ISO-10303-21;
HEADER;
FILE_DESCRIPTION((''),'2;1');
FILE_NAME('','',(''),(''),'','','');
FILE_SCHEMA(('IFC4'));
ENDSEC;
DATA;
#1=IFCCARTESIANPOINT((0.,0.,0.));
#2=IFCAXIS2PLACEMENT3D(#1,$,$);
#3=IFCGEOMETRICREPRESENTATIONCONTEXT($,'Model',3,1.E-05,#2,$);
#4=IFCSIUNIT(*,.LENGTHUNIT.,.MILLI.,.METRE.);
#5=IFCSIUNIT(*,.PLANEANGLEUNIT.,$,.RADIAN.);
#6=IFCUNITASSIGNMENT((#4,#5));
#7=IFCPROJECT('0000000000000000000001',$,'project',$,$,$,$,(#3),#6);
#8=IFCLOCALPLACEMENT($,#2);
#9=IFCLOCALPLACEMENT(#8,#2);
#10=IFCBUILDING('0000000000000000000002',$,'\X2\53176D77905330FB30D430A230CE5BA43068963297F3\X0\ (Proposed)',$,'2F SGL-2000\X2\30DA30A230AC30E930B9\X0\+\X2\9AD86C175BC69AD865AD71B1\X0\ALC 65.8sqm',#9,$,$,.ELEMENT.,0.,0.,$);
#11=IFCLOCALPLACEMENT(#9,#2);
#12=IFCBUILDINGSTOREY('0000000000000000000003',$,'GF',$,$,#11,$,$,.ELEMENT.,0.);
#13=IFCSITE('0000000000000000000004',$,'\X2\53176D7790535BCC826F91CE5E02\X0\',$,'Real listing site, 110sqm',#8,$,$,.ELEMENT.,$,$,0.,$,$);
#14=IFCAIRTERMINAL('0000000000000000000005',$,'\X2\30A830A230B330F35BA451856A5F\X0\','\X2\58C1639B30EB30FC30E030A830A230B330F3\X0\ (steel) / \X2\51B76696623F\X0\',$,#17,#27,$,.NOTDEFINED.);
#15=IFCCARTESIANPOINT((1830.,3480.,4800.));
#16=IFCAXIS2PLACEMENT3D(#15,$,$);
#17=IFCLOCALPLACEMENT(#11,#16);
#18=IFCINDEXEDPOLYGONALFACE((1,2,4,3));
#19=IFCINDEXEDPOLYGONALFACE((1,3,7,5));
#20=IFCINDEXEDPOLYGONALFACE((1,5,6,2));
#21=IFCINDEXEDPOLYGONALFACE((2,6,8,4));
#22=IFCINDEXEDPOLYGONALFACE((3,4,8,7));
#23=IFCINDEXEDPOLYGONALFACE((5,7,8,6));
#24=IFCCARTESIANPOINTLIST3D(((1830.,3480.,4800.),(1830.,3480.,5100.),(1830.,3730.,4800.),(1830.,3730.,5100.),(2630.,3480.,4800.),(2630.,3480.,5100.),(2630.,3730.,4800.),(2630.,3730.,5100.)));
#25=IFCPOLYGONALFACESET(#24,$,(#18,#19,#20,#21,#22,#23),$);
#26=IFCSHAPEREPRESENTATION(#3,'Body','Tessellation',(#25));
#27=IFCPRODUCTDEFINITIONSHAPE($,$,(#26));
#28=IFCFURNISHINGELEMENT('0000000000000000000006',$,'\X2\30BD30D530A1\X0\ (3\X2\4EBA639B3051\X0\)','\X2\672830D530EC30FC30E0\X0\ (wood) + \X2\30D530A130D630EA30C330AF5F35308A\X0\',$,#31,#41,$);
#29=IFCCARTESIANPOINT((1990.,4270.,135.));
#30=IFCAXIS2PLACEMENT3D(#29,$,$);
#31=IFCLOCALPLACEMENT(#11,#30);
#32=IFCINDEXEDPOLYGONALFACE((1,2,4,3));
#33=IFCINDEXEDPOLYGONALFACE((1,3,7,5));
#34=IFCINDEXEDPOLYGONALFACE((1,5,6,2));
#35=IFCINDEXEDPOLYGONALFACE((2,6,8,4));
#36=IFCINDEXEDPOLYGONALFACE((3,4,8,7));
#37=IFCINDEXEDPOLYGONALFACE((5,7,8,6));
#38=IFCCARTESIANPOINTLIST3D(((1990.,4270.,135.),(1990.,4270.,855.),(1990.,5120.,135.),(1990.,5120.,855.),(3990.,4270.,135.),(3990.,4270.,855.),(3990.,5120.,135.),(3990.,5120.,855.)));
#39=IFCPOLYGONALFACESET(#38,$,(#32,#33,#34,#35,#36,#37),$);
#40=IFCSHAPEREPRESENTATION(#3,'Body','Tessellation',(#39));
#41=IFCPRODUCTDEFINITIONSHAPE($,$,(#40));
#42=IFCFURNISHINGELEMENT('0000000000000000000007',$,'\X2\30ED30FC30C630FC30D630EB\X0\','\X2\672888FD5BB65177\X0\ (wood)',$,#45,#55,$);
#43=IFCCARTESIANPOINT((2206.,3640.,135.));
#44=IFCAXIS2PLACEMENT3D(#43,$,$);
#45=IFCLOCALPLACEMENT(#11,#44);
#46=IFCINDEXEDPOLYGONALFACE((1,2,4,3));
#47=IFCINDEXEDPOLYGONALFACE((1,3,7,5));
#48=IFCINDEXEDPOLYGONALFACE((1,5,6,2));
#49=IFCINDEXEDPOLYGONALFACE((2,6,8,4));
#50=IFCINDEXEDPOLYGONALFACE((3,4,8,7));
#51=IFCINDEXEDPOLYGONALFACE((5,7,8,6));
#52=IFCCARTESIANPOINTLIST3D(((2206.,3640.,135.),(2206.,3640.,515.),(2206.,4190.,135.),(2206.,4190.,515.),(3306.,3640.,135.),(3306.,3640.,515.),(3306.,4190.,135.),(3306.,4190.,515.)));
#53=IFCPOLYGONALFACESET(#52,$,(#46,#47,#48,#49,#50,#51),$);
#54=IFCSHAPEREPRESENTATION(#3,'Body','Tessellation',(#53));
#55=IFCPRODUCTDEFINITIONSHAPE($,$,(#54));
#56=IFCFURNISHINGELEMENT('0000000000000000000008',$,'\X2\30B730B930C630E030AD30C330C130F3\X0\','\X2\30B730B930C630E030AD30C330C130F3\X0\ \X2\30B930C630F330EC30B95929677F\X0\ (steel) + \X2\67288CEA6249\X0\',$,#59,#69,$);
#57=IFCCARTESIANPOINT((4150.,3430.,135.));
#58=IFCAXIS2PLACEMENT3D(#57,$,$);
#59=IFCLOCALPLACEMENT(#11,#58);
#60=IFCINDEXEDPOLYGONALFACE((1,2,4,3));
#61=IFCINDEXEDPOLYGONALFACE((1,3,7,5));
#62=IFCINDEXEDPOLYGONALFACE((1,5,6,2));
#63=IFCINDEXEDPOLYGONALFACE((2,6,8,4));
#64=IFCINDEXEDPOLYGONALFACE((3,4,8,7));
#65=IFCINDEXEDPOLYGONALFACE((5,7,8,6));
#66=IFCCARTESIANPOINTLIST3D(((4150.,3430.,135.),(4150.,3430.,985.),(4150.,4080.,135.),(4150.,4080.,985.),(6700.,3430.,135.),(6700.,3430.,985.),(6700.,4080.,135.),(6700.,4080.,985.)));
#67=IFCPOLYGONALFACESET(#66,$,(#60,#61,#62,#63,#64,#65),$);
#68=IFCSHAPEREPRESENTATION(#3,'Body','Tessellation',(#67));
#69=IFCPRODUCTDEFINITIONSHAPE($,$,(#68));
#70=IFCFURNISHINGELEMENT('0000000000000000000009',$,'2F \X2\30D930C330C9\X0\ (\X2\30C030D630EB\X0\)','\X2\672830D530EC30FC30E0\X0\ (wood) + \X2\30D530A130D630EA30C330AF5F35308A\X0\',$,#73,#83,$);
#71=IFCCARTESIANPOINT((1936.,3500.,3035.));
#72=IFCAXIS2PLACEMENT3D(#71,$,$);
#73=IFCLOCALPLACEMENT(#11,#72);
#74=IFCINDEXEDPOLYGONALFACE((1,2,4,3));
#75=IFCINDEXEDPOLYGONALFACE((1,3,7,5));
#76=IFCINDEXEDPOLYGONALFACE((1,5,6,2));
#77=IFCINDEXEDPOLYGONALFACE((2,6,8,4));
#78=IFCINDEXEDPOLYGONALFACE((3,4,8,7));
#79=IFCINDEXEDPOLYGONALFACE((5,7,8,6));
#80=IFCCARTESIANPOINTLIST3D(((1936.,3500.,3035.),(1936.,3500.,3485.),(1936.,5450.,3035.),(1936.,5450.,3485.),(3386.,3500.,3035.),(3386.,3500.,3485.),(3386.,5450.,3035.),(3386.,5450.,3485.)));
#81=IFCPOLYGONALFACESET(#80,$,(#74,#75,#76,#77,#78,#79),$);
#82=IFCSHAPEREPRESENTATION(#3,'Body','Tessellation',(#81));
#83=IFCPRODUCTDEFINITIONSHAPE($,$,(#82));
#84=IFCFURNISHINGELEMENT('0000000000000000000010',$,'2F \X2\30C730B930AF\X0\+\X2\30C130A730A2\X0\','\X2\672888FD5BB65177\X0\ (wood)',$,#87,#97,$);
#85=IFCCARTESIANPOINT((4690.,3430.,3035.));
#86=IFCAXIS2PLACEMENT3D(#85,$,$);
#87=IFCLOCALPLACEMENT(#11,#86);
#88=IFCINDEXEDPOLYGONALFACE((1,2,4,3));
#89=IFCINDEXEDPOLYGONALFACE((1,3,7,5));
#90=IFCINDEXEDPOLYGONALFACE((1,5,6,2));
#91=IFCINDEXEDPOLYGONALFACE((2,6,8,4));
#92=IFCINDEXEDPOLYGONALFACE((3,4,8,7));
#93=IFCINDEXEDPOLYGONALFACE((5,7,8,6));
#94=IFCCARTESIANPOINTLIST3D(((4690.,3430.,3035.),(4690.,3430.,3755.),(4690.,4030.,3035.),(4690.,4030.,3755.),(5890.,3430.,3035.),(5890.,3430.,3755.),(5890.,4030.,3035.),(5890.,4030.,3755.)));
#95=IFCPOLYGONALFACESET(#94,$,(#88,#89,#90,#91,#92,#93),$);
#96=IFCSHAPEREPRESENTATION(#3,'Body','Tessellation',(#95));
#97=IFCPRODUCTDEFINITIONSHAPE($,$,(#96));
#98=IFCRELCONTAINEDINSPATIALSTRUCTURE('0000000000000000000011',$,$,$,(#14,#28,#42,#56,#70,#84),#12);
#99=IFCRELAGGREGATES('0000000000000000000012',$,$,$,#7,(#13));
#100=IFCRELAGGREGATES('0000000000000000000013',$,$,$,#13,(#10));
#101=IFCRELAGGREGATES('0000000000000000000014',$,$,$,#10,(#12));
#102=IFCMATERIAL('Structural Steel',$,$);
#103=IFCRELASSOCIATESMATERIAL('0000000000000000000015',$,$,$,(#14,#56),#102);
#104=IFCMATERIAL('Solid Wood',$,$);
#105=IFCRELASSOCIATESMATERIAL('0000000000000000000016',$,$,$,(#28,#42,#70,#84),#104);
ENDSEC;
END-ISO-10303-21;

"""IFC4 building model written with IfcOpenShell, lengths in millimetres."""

from ifc_helpers import new_model, si_unit, frame, frame_2d, origin, place, context, project, spatial, rectangle, extrude, material, element, save


model = new_model("IFC4")

# Units and contexts
model_context = context("Model", 3, precision=1e-05, world=origin())
ifc_project = project(units=[si_unit("LENGTHUNIT", "METRE", prefix="MILLI"), si_unit("PLANEANGLEUNIT", "RADIAN")], contexts=[model_context])

# Site, building, storey
site_placement = place(None, origin())
site = spatial("IfcSite", under=ifc_project, at=site_placement, Name="北海道富良野市", ObjectType="Real listing site, 110sqm", CompositionType="ELEMENT", RefElevation=0.0)
building_placement = place(site_placement, origin())
building = spatial("IfcBuilding", under=site, at=building_placement, Name="北海道・ピアノ室と防音 (Proposed)", ObjectType="2F SGL-2000ペアガラス+高気密高断熱ALC 65.8sqm", CompositionType="ELEMENT", ElevationOfRefHeight=0.0, ElevationOfTerrain=0.0)
storey_placement = place(building_placement, origin())
storey = spatial("IfcBuildingStorey", under=building, at=storey_placement, Name="GF", CompositionType="ELEMENT", Elevation=0.0)

# Shared definitions
ifc_material_1 = material(Name="Solid Wood")

# Shared definitions
ifc_material_2 = material(Name="Structural Steel")

# Air terminal
air_terminal_placement = place(storey_placement, frame((1830.0, 3480.0, 4800.0)))
element("IfcAirTerminal", 1, at=air_terminal_placement, inside=storey, material=ifc_material_2, Name="エアコン室内機", Description="壁掛ルームエアコン (steel) / 冷暖房", PredefinedType="NOTDEFINED", context=model_context, shape_type="SweptSolid", body=[
    extrude(rectangle(XDim=800.0, YDim=250.0, at=frame_2d((400.0, 125.0))), frame((1830.0, 3480.0, 4800.0)), (0.0, 0.0, 1.0), 300.0),
])

# Furnishing elements
furnishing_1_placement = place(storey_placement, frame((1990.0, 4270.0, 135.0)))
element("IfcFurnishingElement", 2, at=furnishing_1_placement, inside=storey, material=ifc_material_1, Name="ソファ (3人掛け)", Description="木フレーム (wood) + ファブリック張り", context=model_context, shape_type="SweptSolid", body=[
    extrude(rectangle(XDim=2000.0, YDim=850.0, at=frame_2d((1000.0, 425.0))), frame((1990.0, 4270.0, 135.0)), (0.0, 0.0, 1.0), 720.0),
])
furnishing_2_placement = place(storey_placement, frame((2206.0, 3640.0, 135.0)))
element("IfcFurnishingElement", 3, at=furnishing_2_placement, inside=storey, material=ifc_material_1, Name="ローテーブル", Description="木製家具 (wood)", context=model_context, shape_type="SweptSolid", body=[
    extrude(rectangle(XDim=1100.0, YDim=550.0, at=frame_2d((550.0, 275.0))), frame((2206.0, 3640.0, 135.0)), (0.0, 0.0, 1.0), 380.0),
])
furnishing_3_placement = place(storey_placement, frame((4150.0, 3430.0, 135.0)))
element("IfcFurnishingElement", 4, at=furnishing_3_placement, inside=storey, material=ifc_material_2, Name="システムキッチン", Description="システムキッチン ステンレス天板 (steel) + 木質扉", context=model_context, shape_type="SweptSolid", body=[
    extrude(rectangle(XDim=2550.0, YDim=650.0, at=frame_2d((1275.0, 325.0))), frame((4150.0, 3430.0, 135.0)), (0.0, 0.0, 1.0), 850.0),
])
furnishing_4_placement = place(storey_placement, frame((1936.0, 3500.0, 3035.0)))
element("IfcFurnishingElement", 5, at=furnishing_4_placement, inside=storey, material=ifc_material_1, Name="2F ベッド (ダブル)", Description="木フレーム (wood) + ファブリック張り", context=model_context, shape_type="SweptSolid", body=[
    extrude(rectangle(XDim=1450.0, YDim=1950.0, at=frame_2d((725.0, 975.0))), frame((1936.0, 3500.0, 3035.0)), (0.0, 0.0, 1.0), 450.0),
])
furnishing_5_placement = place(storey_placement, frame((4690.0, 3430.0, 3035.0)))
element("IfcFurnishingElement", 6, at=furnishing_5_placement, inside=storey, material=ifc_material_1, Name="2F デスク+チェア", Description="木製家具 (wood)", context=model_context, shape_type="SweptSolid", body=[
    extrude(rectangle(XDim=1200.0, YDim=600.0, at=frame_2d((600.0, 300.0))), frame((4690.0, 3430.0, 3035.0)), (0.0, 0.0, 1.0), 720.0),
])

save(model, "model.ifc")
